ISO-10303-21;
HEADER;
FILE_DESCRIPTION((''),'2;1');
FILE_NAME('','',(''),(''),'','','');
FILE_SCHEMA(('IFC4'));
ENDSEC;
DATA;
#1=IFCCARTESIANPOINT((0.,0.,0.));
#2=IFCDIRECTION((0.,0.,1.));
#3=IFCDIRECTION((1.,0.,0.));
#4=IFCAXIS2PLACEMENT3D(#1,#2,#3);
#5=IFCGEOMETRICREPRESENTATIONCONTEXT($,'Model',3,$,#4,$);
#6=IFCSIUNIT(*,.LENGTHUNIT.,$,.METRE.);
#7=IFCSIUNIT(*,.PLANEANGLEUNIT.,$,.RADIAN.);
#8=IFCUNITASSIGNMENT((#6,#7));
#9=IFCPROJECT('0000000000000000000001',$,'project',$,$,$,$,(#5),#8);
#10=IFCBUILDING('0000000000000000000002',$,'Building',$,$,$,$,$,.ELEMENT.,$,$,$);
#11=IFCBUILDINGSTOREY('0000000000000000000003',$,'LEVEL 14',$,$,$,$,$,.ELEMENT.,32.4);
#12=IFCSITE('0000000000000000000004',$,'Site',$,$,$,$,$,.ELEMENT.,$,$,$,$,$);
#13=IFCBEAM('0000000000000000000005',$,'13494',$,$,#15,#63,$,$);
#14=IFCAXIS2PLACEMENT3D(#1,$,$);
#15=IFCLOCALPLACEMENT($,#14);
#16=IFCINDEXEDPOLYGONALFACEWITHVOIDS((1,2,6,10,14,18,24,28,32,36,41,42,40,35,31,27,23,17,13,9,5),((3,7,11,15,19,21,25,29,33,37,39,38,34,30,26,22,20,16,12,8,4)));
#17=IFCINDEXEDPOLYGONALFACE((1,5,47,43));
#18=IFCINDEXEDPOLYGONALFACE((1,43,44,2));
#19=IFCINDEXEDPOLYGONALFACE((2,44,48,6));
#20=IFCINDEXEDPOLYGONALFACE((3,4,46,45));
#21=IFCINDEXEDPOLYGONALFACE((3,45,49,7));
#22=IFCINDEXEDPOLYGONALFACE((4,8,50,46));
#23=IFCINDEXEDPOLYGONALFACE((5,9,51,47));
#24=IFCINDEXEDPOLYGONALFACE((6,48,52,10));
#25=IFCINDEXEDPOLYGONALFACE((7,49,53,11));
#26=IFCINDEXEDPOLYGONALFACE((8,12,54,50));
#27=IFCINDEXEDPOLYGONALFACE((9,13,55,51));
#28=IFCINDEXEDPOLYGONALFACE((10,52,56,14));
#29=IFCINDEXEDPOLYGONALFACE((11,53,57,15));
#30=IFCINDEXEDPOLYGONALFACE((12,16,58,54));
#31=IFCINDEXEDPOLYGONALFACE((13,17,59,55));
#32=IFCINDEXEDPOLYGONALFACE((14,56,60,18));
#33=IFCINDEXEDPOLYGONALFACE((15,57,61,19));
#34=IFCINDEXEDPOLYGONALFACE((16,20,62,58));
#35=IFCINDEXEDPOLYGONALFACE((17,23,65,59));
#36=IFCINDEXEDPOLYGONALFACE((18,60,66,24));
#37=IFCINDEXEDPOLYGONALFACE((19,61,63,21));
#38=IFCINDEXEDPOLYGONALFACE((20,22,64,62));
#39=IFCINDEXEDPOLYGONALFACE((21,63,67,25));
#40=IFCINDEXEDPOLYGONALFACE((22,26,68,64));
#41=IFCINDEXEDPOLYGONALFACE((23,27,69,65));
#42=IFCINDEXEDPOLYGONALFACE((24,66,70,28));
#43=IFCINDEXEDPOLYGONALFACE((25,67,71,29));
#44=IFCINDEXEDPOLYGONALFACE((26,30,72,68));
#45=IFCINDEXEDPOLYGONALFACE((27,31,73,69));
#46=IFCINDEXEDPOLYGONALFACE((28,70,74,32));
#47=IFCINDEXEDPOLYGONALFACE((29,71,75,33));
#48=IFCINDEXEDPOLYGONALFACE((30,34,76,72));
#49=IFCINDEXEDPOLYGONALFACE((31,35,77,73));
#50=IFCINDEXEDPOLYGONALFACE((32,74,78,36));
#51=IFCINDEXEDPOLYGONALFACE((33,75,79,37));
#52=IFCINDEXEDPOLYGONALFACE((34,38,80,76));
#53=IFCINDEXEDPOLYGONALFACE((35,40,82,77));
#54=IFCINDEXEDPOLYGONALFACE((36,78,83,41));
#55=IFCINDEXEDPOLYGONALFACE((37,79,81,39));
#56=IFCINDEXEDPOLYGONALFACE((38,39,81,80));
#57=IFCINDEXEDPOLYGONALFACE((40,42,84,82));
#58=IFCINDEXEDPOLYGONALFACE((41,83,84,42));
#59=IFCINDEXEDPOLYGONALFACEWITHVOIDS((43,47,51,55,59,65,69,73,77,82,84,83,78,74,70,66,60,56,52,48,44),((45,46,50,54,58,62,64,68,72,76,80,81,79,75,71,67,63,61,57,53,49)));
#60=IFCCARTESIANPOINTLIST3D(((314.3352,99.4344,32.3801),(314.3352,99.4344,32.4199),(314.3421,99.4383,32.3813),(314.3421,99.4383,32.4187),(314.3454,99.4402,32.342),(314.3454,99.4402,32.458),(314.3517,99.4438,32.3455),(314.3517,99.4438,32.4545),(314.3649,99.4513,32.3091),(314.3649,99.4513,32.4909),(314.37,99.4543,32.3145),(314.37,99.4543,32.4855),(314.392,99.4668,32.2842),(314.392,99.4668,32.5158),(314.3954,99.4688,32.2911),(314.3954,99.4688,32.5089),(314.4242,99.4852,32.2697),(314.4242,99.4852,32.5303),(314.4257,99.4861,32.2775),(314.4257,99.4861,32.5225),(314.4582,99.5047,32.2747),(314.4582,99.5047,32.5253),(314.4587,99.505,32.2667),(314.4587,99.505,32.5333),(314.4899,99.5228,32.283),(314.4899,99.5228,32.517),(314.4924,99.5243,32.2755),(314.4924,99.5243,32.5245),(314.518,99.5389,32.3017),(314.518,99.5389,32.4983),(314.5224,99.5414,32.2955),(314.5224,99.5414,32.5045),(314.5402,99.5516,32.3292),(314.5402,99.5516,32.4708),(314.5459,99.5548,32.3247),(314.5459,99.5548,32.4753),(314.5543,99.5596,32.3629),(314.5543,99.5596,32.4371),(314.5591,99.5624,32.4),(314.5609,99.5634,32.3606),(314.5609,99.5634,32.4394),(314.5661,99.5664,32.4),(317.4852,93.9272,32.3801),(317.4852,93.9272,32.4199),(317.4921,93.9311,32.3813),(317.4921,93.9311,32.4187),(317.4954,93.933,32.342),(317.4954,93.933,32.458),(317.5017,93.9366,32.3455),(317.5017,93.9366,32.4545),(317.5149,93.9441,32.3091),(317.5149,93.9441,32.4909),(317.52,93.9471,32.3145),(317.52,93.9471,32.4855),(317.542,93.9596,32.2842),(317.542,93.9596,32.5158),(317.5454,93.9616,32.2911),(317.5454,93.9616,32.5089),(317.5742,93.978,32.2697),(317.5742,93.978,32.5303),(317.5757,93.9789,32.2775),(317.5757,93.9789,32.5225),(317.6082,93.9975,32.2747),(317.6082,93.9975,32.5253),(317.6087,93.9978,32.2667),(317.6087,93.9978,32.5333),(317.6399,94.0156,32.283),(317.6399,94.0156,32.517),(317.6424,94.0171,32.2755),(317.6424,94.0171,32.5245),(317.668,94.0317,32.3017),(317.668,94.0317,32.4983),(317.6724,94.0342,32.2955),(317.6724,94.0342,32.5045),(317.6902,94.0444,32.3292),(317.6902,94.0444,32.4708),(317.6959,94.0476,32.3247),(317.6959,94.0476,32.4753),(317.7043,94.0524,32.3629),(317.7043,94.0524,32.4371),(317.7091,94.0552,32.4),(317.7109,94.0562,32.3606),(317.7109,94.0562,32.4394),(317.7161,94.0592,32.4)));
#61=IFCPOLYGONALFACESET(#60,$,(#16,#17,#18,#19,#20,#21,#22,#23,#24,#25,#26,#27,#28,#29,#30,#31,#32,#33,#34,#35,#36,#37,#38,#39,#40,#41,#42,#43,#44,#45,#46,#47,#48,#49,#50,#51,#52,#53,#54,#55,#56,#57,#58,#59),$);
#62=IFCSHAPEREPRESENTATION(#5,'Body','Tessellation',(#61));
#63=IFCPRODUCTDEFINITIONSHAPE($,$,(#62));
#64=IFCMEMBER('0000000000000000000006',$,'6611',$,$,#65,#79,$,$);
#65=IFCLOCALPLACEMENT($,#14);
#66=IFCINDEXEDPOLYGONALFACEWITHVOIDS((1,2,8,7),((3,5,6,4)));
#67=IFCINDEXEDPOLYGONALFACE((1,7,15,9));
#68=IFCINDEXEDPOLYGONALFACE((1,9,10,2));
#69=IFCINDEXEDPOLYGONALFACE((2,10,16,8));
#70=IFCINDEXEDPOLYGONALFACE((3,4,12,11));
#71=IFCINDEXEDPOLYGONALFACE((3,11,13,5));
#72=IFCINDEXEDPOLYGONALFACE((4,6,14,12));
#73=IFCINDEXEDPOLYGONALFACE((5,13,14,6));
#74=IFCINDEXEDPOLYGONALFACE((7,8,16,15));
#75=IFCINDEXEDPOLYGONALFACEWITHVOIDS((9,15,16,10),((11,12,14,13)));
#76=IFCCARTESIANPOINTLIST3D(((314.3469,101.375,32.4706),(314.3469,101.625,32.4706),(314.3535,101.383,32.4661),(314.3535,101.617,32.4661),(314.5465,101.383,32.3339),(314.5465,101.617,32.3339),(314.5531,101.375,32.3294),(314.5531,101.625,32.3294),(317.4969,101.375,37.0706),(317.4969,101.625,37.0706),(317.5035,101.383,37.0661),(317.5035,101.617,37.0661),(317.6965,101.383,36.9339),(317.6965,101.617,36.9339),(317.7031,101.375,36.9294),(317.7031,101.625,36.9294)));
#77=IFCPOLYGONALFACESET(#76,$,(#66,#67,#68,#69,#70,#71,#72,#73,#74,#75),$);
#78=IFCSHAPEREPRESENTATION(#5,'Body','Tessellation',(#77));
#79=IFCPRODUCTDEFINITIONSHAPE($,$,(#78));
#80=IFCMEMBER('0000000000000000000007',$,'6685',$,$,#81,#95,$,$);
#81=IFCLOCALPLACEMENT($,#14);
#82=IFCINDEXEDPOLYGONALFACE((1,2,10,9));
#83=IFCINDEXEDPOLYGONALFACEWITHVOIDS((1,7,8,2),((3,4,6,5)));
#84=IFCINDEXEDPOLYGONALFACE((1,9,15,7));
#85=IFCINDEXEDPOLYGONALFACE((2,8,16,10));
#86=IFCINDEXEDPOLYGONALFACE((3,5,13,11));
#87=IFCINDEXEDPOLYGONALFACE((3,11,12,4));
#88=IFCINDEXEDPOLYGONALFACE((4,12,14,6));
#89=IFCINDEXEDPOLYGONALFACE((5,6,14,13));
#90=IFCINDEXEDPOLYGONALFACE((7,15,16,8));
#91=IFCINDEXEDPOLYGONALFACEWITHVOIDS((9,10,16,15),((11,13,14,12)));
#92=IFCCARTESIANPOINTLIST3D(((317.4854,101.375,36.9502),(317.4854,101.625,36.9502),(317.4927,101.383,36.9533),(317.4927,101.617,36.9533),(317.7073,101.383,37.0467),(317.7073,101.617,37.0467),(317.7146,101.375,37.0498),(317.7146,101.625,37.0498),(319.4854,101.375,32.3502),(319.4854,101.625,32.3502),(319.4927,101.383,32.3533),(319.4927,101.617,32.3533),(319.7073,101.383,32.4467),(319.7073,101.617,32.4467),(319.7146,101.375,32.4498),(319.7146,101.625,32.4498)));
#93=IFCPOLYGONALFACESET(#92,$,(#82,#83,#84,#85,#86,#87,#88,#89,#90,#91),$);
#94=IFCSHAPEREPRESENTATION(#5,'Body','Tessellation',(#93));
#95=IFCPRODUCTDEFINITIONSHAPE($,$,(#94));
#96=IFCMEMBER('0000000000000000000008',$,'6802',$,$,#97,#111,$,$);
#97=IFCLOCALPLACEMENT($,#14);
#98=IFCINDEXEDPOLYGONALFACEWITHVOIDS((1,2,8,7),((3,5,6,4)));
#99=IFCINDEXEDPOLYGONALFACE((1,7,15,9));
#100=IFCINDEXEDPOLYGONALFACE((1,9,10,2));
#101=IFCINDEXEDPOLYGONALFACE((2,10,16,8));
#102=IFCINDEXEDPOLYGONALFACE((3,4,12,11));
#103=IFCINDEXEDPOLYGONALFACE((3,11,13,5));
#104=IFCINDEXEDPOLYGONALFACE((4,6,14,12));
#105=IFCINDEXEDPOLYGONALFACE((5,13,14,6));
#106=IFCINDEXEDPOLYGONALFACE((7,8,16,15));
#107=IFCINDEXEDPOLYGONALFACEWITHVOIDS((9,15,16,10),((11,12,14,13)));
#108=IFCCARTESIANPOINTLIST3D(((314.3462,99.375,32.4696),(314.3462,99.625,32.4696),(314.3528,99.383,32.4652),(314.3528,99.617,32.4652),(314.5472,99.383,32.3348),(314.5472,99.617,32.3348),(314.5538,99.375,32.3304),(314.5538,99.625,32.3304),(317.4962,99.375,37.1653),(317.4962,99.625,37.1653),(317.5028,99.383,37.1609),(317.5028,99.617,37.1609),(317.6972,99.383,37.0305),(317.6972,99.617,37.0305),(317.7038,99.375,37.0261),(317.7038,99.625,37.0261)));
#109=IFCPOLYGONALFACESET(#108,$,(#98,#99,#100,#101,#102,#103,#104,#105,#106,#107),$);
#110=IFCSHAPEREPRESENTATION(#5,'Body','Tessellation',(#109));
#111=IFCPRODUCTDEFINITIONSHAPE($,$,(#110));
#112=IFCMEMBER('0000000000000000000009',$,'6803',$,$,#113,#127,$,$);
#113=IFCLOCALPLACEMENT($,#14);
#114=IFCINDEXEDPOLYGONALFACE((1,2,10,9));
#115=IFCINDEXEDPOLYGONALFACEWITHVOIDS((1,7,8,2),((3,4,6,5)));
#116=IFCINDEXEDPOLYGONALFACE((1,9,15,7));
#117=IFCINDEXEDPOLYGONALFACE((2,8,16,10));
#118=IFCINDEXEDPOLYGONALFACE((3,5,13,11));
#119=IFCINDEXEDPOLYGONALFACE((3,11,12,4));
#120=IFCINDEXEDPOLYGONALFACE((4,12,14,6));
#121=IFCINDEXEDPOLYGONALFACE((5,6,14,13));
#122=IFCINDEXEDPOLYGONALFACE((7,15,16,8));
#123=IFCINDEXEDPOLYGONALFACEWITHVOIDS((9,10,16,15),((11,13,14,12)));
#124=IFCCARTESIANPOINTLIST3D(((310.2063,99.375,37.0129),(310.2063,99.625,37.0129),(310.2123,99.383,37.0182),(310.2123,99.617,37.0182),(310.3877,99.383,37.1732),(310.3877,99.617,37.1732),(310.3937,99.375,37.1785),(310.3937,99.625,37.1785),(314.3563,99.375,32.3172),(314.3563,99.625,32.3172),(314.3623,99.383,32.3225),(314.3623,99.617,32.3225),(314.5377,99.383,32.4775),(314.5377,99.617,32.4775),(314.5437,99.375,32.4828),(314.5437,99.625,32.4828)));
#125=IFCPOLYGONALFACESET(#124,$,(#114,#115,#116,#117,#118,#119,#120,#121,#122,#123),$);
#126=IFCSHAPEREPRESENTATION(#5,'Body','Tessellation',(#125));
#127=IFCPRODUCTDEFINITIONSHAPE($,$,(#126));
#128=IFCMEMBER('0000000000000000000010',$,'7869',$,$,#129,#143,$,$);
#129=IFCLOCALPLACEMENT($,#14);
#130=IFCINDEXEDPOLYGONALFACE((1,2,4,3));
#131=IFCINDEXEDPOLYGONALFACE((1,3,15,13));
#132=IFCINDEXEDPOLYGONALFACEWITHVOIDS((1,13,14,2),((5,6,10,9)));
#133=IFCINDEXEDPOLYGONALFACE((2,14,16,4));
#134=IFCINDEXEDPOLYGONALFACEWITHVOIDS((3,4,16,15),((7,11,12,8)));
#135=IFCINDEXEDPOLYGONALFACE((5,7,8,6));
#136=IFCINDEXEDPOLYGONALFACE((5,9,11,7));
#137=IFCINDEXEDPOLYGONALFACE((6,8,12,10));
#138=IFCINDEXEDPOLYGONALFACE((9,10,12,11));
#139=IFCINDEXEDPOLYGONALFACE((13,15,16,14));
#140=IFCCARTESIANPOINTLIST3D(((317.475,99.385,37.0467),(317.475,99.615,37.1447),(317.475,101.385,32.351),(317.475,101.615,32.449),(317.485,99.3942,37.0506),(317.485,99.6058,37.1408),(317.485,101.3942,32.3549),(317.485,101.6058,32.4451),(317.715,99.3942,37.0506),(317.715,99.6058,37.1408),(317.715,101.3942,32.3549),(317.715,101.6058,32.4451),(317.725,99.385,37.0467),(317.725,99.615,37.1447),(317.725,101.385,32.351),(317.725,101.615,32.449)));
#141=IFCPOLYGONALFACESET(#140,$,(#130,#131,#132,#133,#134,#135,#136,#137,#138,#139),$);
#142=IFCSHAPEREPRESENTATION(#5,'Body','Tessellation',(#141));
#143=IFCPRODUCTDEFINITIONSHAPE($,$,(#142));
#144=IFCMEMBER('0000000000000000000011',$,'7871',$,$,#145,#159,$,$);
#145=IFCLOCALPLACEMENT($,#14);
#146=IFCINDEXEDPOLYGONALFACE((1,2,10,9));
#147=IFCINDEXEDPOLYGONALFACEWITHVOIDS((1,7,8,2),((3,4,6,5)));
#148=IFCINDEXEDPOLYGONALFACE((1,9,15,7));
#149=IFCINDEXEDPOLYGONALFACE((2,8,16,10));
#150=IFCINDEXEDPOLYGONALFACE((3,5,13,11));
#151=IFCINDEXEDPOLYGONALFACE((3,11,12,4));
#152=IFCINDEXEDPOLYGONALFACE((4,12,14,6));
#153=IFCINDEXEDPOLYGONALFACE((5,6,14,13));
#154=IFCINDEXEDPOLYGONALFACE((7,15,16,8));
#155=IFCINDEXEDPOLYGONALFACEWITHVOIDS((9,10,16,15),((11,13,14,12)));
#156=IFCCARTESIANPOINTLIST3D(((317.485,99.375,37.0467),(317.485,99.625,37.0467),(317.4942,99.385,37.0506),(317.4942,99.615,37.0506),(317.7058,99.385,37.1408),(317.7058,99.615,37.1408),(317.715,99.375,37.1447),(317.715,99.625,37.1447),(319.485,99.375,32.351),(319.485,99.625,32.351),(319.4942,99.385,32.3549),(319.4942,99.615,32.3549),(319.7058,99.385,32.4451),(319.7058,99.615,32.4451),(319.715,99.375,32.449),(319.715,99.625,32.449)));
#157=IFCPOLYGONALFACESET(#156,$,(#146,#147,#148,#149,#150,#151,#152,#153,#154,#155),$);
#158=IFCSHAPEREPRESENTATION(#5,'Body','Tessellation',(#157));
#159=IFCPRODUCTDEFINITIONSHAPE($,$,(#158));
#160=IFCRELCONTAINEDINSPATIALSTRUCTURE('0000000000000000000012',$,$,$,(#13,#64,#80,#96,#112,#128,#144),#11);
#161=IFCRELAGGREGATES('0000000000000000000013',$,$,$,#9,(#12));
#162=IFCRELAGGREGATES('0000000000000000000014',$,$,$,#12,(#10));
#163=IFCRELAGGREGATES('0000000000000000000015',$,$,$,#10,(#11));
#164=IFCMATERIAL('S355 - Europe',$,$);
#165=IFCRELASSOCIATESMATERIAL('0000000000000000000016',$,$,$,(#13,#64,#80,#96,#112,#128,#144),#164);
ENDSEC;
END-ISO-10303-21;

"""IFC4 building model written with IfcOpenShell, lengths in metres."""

from ifc_helpers import new_model, si_unit, frame, origin_with_axes, origin_2d_with_axis, place, context, project, spatial, hollow_rectangle, hollow_circle, extrude, material, material_profile, profile_set, profile_usage, element, save


model = new_model("IFC4")

# Units and contexts
model_context = context("Model", 3, world=origin_with_axes())
ifc_project = project(units=[si_unit("LENGTHUNIT", "METRE"), si_unit("PLANEANGLEUNIT", "RADIAN")], contexts=[model_context])

# Site, building, storey
site = spatial("IfcSite", under=ifc_project, Name="Site", CompositionType="ELEMENT")
building = spatial("IfcBuilding", under=site, Name="Building", CompositionType="ELEMENT")
storey = spatial("IfcBuildingStorey", under=building, Name="LEVEL 14", CompositionType="ELEMENT", Elevation=32.4)

# Shared definitions
ifc_material = material(Name="S355 - Europe")

# Beam
ifc_material_profile_1 = material_profile(ifc_material, hollow_circle(Radius=0.1337, WallThickness=0.008, at=origin_2d_with_axis()))
ifc_profile_set_1 = profile_set([ifc_material_profile_1])
ifc_profile_usage_1 = profile_usage(ifc_profile_set_1, cardinal=10)
beam_1_placement = place(None, frame((314.45, 99.5, 32.4), z_axis=(0.496499, -0.868037, 0.0), x_axis=(0.868037, 0.496499, 0.0)))
element("IfcBeam", 1, at=beam_1_placement, inside=storey, material=ifc_profile_usage_1, Name="13494", context=model_context, shape_type="SweptSolid", body=[
    extrude(hollow_circle(Radius=0.1337, WallThickness=0.008, at=origin_2d_with_axis()), origin_with_axes(), (0.0, 0.0, 1.0), 6.3444),
])

# Members
ifc_material_profile_2 = material_profile(ifc_material, hollow_rectangle(XDim=0.25, YDim=0.25, WallThickness=0.008, at=origin_2d_with_axis()))
ifc_profile_set_2 = profile_set([ifc_material_profile_2])
ifc_profile_usage_2 = profile_usage(ifc_profile_set_2, cardinal=10)
member_1_placement = place(None, frame((314.45, 101.5, 32.4), z_axis=(0.565005, 0.0, 0.825087), x_axis=(0.0, 1.0, 0.0)))
element("IfcMember", 2, at=member_1_placement, inside=storey, material=ifc_profile_usage_2, Name="6611", context=model_context, shape_type="SweptSolid", body=[
    extrude(hollow_rectangle(XDim=0.25, YDim=0.25, WallThickness=0.008, at=origin_2d_with_axis()), origin_with_axes(), (0.0, 0.0, 1.0), 5.5752),
])
ifc_material_profile_3 = material_profile(ifc_material, hollow_rectangle(XDim=0.25, YDim=0.25, WallThickness=0.008, at=origin_2d_with_axis()))
ifc_profile_set_3 = profile_set([ifc_material_profile_3])
ifc_profile_usage_3 = profile_usage(ifc_profile_set_3, cardinal=10)
member_2_placement = place(None, frame((317.6, 101.5, 37.0), z_axis=(0.398726, 0.0, -0.91707), x_axis=(0.0, 1.0, 0.0)))
element("IfcMember", 3, at=member_2_placement, inside=storey, material=ifc_profile_usage_3, Name="6685", context=model_context, shape_type="SweptSolid", body=[
    extrude(hollow_rectangle(XDim=0.25, YDim=0.25, WallThickness=0.008, at=origin_2d_with_axis()), origin_with_axes(), (0.0, 0.0, 1.0), 5.016),
])
ifc_material_profile_4 = material_profile(ifc_material, hollow_rectangle(XDim=0.25, YDim=0.25, WallThickness=0.008, at=origin_2d_with_axis()))
ifc_profile_set_4 = profile_set([ifc_material_profile_4])
ifc_profile_usage_4 = profile_usage(ifc_profile_set_4, cardinal=10)
member_3_placement = place(None, frame((317.6, 99.5, 37.0957), z_axis=(-0.55709, 0.0, -0.830452), x_axis=(0.0, -1.0, 0.0)))
element("IfcMember", 4, at=member_3_placement, inside=storey, material=ifc_profile_usage_4, Name="6802", context=model_context, shape_type="SweptSolid", body=[
    extrude(hollow_rectangle(XDim=0.25, YDim=0.25, WallThickness=0.008, at=origin_2d_with_axis()), origin_with_axes(), (0.0, 0.0, 1.0), 5.6544),
])
ifc_material_profile_5 = material_profile(ifc_material, hollow_rectangle(XDim=0.25, YDim=0.25, WallThickness=0.008, at=origin_2d_with_axis()))
ifc_profile_set_5 = profile_set([ifc_material_profile_5])
ifc_profile_usage_5 = profile_usage(ifc_profile_set_5, cardinal=10)
member_4_placement = place(None, frame((314.45, 99.5, 32.4), z_axis=(-0.662226, 0.0, 0.749304), x_axis=(0.0, -1.0, 0.0)))
element("IfcMember", 5, at=member_4_placement, inside=storey, material=ifc_profile_usage_5, Name="6803", context=model_context, shape_type="SweptSolid", body=[
    extrude(hollow_rectangle(XDim=0.25, YDim=0.25, WallThickness=0.008, at=origin_2d_with_axis()), origin_with_axes(), (0.0, 0.0, 1.0), 6.2667),
])
ifc_material_profile_6 = material_profile(ifc_material, hollow_rectangle(XDim=0.25, YDim=0.25, WallThickness=0.01, at=origin_2d_with_axis()))
ifc_profile_set_6 = profile_set([ifc_material_profile_6])
ifc_profile_usage_6 = profile_usage(ifc_profile_set_6, cardinal=10)
member_5_placement = place(None, frame((317.6, 99.5, 37.0957), z_axis=(0.0, 0.391859, -0.920025), x_axis=(-1.0, 0.0, 0.0)))
element("IfcMember", 6, at=member_5_placement, inside=storey, material=ifc_profile_usage_6, Name="7869", context=model_context, shape_type="SweptSolid", body=[
    extrude(hollow_rectangle(XDim=0.25, YDim=0.25, WallThickness=0.01, at=origin_2d_with_axis()), origin_with_axes(), (0.0, 0.0, 1.0), 5.1039),
])
ifc_material_profile_7 = material_profile(ifc_material, hollow_rectangle(XDim=0.25, YDim=0.25, WallThickness=0.01, at=origin_2d_with_axis()))
ifc_profile_set_7 = profile_set([ifc_material_profile_7])
ifc_profile_usage_7 = profile_usage(ifc_profile_set_7, cardinal=10)
member_6_placement = place(None, frame((317.6, 99.5, 37.0957), z_axis=(0.391859, 0.0, -0.920025), x_axis=(0.0, 1.0, 0.0)))
element("IfcMember", 7, at=member_6_placement, inside=storey, material=ifc_profile_usage_7, Name="7871", context=model_context, shape_type="SweptSolid", body=[
    extrude(hollow_rectangle(XDim=0.25, YDim=0.25, WallThickness=0.01, at=origin_2d_with_axis()), origin_with_axes(), (0.0, 0.0, 1.0), 5.1039),
])

save(model, "model.ifc")
